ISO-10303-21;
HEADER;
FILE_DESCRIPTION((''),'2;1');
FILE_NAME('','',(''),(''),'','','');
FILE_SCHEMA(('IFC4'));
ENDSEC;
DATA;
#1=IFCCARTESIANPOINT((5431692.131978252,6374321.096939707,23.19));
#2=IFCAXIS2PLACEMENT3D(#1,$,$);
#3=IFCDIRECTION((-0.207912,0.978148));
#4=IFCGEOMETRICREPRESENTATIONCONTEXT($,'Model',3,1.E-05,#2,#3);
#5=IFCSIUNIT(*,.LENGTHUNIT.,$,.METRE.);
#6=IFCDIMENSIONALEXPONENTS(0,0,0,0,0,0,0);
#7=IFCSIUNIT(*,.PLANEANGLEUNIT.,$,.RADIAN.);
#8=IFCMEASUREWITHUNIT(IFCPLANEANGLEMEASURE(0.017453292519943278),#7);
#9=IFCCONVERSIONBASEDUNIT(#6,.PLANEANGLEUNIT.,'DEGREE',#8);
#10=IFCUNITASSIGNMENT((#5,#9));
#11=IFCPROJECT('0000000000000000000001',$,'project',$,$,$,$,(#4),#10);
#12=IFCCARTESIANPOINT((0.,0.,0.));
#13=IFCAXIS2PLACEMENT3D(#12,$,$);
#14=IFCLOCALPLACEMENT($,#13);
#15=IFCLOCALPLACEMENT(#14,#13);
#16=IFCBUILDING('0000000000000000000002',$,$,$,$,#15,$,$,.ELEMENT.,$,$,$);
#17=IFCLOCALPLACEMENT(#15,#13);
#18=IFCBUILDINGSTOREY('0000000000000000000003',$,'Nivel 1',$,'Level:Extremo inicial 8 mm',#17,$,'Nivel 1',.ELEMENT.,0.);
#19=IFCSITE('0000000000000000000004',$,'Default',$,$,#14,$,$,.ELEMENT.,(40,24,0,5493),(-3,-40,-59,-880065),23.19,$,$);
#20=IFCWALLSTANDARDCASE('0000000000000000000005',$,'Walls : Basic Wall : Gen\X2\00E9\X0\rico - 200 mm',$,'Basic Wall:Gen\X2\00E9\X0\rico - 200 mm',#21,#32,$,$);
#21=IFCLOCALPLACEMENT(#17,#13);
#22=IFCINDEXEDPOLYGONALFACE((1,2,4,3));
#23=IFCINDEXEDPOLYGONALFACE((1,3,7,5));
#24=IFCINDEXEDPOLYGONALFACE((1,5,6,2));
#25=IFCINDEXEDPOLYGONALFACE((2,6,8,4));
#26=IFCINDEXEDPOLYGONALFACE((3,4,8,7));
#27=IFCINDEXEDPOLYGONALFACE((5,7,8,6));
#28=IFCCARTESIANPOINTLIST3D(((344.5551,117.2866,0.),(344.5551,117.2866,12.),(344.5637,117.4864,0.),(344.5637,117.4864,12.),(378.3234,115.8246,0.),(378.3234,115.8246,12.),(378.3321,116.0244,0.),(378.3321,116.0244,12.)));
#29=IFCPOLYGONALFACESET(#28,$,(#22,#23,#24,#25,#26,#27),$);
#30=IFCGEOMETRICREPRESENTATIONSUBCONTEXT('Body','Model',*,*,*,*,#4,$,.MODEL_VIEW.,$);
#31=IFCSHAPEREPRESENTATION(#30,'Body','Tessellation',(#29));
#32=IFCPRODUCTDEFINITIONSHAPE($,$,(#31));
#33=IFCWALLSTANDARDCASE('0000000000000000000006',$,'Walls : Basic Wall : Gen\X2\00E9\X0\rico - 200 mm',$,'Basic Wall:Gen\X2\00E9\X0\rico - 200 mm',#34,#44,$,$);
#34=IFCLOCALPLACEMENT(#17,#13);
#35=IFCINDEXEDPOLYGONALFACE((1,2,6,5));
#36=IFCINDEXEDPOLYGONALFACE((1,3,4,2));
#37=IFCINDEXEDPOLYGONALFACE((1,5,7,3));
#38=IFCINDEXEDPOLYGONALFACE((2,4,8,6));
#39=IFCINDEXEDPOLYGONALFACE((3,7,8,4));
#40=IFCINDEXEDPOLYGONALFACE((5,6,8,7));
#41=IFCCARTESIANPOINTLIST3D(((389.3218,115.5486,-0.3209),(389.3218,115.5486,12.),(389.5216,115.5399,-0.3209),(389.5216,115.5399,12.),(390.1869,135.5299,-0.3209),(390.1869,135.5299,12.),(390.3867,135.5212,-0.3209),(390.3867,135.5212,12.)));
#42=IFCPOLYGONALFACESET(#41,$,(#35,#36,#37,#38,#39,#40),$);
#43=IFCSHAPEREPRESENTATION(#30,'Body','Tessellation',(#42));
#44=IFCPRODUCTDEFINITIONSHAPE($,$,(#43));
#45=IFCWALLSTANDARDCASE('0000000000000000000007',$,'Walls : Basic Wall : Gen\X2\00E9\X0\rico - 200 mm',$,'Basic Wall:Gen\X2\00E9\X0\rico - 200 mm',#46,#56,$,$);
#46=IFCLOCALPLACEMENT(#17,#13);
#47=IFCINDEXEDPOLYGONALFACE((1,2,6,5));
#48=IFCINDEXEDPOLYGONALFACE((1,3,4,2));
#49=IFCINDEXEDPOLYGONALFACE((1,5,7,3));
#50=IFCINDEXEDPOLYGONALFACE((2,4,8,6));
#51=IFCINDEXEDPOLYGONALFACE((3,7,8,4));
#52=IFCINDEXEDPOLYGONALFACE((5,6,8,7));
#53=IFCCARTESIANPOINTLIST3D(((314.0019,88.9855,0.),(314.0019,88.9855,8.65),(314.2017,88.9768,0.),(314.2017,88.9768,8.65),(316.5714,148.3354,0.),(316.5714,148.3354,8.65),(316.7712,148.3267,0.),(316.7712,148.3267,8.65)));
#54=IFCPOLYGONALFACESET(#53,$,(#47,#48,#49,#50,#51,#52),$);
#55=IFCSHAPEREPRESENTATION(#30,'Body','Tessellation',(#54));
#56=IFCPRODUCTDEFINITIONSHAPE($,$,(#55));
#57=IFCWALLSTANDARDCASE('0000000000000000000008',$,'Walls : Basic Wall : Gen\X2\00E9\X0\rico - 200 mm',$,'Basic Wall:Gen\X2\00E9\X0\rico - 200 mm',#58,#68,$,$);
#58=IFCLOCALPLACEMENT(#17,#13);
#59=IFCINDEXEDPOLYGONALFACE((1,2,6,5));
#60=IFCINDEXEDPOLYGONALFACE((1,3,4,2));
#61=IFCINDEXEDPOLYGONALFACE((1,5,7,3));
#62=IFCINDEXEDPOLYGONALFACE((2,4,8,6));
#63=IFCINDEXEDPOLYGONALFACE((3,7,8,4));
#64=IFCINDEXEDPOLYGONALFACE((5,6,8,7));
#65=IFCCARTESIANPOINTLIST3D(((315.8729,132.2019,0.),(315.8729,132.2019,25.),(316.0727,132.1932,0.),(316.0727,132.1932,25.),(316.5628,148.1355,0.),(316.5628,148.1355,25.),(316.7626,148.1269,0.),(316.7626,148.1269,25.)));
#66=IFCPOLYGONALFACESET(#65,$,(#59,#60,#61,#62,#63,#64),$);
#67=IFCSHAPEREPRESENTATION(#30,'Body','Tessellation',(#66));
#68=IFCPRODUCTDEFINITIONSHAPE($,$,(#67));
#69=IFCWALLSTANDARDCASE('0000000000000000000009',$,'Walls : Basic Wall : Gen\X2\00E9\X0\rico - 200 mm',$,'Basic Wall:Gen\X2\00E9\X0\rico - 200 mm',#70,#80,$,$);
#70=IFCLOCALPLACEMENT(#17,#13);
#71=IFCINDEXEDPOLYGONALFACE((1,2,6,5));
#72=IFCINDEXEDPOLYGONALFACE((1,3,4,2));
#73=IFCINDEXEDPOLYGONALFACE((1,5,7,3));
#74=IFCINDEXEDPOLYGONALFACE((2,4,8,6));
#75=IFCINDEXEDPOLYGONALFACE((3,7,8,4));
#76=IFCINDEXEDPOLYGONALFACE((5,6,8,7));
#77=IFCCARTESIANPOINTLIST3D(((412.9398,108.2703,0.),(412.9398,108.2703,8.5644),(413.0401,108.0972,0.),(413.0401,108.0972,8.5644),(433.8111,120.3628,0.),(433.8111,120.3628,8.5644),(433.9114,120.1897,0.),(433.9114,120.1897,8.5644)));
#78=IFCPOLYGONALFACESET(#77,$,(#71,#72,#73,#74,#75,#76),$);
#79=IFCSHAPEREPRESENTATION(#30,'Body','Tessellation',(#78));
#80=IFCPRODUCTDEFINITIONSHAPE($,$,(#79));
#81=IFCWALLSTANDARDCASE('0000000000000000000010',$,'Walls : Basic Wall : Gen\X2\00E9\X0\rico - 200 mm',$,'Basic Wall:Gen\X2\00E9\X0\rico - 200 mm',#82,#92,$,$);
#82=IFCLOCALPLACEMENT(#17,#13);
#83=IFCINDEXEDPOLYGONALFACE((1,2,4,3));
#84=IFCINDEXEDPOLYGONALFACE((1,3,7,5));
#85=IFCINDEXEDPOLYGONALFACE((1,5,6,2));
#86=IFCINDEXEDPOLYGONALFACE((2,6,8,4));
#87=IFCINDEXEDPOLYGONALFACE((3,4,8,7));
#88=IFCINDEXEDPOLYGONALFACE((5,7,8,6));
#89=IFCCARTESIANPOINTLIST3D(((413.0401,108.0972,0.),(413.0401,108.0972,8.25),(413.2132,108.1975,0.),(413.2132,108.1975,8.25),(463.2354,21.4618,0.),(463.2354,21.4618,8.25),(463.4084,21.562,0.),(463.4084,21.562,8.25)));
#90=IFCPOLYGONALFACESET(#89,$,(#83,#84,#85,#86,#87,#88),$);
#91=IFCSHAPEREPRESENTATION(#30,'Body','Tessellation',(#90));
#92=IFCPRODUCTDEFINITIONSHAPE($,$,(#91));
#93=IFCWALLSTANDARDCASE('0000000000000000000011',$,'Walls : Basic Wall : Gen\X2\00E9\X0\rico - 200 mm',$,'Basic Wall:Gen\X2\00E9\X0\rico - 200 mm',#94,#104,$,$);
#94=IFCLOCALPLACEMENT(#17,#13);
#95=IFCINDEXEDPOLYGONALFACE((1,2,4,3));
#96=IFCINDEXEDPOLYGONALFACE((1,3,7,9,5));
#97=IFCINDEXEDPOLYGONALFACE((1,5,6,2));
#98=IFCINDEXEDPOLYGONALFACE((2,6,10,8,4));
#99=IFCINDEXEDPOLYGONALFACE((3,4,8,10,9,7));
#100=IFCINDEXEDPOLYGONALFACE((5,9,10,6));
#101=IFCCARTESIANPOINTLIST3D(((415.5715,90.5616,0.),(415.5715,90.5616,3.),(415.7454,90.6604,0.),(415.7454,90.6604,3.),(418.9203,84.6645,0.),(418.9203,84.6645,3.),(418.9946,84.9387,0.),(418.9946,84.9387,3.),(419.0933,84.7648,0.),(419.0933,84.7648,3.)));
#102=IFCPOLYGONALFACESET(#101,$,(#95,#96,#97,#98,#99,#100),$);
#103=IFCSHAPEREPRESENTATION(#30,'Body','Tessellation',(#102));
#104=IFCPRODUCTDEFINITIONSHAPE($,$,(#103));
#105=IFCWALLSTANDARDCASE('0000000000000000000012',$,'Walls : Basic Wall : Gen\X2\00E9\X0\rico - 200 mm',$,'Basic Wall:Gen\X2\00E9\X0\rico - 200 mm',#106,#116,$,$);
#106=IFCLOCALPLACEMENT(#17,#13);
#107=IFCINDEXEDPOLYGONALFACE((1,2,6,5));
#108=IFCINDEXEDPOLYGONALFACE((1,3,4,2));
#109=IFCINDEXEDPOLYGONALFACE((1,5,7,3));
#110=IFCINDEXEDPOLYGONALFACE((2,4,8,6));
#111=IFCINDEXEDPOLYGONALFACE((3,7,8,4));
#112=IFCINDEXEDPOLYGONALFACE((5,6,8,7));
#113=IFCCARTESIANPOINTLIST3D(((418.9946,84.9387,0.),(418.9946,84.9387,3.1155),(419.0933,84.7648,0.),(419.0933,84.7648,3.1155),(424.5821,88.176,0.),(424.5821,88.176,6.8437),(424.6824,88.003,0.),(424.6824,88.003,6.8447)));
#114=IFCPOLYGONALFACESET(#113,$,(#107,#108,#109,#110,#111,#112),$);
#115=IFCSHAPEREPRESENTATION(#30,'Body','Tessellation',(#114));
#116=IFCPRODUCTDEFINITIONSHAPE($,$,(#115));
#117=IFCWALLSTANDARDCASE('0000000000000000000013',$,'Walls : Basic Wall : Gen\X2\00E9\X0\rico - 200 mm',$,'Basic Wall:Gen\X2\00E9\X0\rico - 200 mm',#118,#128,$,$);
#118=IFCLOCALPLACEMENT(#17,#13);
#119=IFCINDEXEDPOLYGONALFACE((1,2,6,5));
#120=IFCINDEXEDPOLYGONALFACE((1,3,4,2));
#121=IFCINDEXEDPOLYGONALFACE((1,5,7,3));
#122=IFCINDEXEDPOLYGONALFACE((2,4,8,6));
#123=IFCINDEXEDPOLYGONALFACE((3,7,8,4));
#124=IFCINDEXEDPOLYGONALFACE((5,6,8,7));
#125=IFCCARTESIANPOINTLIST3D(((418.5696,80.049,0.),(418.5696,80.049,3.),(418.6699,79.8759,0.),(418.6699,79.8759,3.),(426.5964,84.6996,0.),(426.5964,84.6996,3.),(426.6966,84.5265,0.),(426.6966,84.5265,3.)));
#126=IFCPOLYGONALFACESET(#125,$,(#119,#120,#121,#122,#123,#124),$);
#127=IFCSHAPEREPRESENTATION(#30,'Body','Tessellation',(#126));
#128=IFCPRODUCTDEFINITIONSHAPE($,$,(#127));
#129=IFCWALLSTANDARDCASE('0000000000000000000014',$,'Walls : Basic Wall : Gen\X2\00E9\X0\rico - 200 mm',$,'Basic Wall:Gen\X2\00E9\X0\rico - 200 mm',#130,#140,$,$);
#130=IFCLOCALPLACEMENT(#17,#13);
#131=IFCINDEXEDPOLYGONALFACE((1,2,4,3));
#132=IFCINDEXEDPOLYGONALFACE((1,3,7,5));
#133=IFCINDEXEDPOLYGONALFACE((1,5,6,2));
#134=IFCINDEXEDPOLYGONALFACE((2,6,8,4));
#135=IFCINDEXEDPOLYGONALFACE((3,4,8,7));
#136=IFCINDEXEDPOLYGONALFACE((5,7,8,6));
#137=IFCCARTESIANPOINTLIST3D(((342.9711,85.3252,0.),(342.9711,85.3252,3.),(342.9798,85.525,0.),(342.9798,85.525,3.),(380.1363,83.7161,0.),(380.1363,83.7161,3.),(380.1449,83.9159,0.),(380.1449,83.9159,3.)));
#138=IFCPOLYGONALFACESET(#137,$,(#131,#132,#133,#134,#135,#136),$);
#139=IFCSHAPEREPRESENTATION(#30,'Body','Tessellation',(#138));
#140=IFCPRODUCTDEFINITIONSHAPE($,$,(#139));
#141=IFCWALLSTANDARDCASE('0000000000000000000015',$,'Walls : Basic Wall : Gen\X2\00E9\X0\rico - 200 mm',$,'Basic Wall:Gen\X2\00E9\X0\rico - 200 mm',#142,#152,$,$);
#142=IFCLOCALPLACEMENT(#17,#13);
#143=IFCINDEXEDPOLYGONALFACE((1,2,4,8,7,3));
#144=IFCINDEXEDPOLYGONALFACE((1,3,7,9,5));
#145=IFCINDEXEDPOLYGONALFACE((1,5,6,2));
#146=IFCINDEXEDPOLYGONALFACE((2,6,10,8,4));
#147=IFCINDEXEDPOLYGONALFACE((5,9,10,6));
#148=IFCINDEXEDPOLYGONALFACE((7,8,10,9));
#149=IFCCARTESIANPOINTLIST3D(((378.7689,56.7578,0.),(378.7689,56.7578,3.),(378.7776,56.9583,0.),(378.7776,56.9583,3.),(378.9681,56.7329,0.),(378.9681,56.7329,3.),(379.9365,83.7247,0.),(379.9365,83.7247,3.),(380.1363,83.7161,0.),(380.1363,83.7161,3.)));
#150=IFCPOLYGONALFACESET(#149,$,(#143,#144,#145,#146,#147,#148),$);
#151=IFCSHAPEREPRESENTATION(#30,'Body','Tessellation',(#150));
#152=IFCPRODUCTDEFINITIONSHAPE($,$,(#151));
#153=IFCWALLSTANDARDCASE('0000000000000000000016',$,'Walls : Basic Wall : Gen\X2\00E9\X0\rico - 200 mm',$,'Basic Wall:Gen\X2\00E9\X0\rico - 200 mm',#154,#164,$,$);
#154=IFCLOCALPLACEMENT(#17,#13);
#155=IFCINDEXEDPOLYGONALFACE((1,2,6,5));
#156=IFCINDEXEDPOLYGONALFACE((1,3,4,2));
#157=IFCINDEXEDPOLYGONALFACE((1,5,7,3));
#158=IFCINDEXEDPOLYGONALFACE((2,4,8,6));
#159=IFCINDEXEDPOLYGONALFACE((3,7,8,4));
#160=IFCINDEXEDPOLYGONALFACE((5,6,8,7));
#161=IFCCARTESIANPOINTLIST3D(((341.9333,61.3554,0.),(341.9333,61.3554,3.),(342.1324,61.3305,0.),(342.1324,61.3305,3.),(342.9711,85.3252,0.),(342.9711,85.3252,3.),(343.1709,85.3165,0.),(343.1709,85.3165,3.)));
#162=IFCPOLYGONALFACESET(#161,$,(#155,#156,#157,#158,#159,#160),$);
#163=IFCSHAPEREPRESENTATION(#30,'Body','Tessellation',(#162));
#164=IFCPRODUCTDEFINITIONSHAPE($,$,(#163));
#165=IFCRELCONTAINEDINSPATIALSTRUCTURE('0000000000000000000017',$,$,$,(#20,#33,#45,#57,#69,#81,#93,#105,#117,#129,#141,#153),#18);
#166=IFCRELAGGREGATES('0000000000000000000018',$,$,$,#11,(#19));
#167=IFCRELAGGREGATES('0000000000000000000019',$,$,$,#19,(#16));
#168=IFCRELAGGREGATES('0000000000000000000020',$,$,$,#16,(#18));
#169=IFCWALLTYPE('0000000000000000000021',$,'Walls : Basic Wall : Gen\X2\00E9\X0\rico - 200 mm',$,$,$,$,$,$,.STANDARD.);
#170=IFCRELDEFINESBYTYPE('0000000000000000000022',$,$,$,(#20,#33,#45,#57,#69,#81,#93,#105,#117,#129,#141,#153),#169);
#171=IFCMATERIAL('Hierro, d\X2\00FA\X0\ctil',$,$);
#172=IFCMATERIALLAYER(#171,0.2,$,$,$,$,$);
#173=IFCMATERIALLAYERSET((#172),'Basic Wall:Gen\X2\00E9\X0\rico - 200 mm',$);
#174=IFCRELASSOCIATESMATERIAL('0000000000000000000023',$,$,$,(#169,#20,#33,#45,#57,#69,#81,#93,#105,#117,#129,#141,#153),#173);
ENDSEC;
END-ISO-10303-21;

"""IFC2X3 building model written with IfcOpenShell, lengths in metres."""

from ifc_helpers import new_model, entity, si_unit, converted_unit, direction, frame, frame_2d, origin, place, context, subcontext, project, spatial, polyline, rectangle, outline, extrude, clip, bounded_halfspace, material, layer, layer_set, layer_usage, type_object, element, save


model = new_model("IFC2X3")

# Units and contexts
model_context = context("Model", 3, precision=1e-05, world=frame((5431692.131978252, 6374321.096939707, 23.19)), true_north=direction((-0.207912, 0.978148)))
body_context = subcontext(model_context, "Body", "Model", "MODEL_VIEW")
ifc_project = project(units=[si_unit("LENGTHUNIT", "METRE"), converted_unit("PLANEANGLEUNIT", "DEGREE", entity("IfcPlaneAngleMeasure", 0.017453292519943278), si_unit("PLANEANGLEUNIT", "RADIAN"), dimensions=[0, 0, 0, 0, 0, 0, 0])], contexts=[model_context])

# Site, building, storey
site_placement = place(None, origin())
site = spatial("IfcSite", under=ifc_project, at=site_placement, Name="Default", CompositionType="ELEMENT", RefLatitude=(40, 24, 0, 5493), RefLongitude=(-3, -40, -59, -880065), RefElevation=23.19)
building_placement = place(site_placement, origin())
building = spatial("IfcBuilding", under=site, at=building_placement, CompositionType="ELEMENT")
storey_placement = place(building_placement, origin())
storey = spatial("IfcBuildingStorey", under=building, at=storey_placement, Name="Nivel 1", ObjectType="Level:Extremo inicial 8 mm", LongName="Nivel 1", CompositionType="ELEMENT", Elevation=0.0)

# Walls
ifc_material = material(Name="Hierro, dúctil")
ifc_layer = layer(ifc_material, 0.2)
ifc_layer_set = layer_set([ifc_layer], Name="Basic Wall:Genérico - 200 mm")
ifc_layer_usage_1 = layer_usage(ifc_layer_set, "AXIS2", "NEGATIVE", 0.1)
wall_type = type_object("IfcWallType", Name="Walls : Basic Wall : Genérico - 200 mm", PredefinedType="STANDARD", material=ifc_layer_set)
wall_1_placement = place(storey_placement, frame((344.5594, 117.3865, 0.0), z_axis=(0.0, 0.0, 1.0), x_axis=(0.999064, -0.043255, 0.0)))
element("IfcWallStandardCase", 1, at=wall_1_placement, inside=storey, type_object=wall_type, material=ifc_layer_usage_1, Name="Walls : Basic Wall : Genérico - 200 mm", ObjectType="Basic Wall:Genérico - 200 mm", context=body_context, shape_type="SweptSolid", body=[
    extrude(rectangle(XDim=33.8, YDim=0.2, at=frame_2d((16.9, 0.0), x_axis=(-1.0, 0.0))), origin(), (0.0, 0.0, 1.0), 12.0),
])
ifc_layer_usage_2 = layer_usage(ifc_layer_set, "AXIS2", "NEGATIVE", 0.1)
wall_2_placement = place(storey_placement, frame((389.4217, 115.5442, -0.3209), z_axis=(0.0, 0.0, 1.0), x_axis=(0.043255, 0.999064, 0.0)))
element("IfcWallStandardCase", 2, at=wall_2_placement, inside=storey, type_object=wall_type, material=ifc_layer_usage_2, Name="Walls : Basic Wall : Genérico - 200 mm", ObjectType="Basic Wall:Genérico - 200 mm", context=body_context, shape_type="Clipping", body=[
    clip(clip(extrude(rectangle(XDim=20.0, YDim=0.2, at=frame_2d((10.0, 0.0), x_axis=(-1.0, 0.0))), origin(), (0.0, 0.0, 1.0), 12.3209), bounded_halfspace(frame((9.8, -0.1, 12.3209), z_axis=(0.0, 0.0, 1.0), x_axis=(0.043255, -0.999064, 0.0)), False, frame((9.8, -0.1, 12.3209)), polyline([(0.0, 0.0), (10.2, 0.0), (10.2, 0.2), (10.0, 0.2), (0.0, 0.2), (0.0, 0.0)]))), bounded_halfspace(frame((0.0, -0.1, 12.3209), z_axis=(0.0, 0.0, 1.0), x_axis=(0.043255, -0.999064, 0.0)), False, frame((0.0, -0.1, 12.3209)), polyline([(0.0, 0.0), (9.8, 0.0), (9.8, 0.2), (0.0, 0.2), (0.0, 0.0)]))),
])
ifc_layer_usage_3 = layer_usage(ifc_layer_set, "AXIS2", "NEGATIVE", 0.1)
wall_3_placement = place(storey_placement, frame((314.1018, 88.9812, 0.0), z_axis=(0.0, 0.0, 1.0), x_axis=(0.043255, 0.999064, 0.0)))
element("IfcWallStandardCase", 3, at=wall_3_placement, inside=storey, type_object=wall_type, material=ifc_layer_usage_3, Name="Walls : Basic Wall : Genérico - 200 mm", ObjectType="Basic Wall:Genérico - 200 mm", context=body_context, shape_type="SweptSolid", body=[
    extrude(rectangle(XDim=59.4055, YDim=0.2, at=frame_2d((29.7027, 0.0), x_axis=(-1.0, 0.0))), origin(), (0.0, 0.0, 1.0), 8.65),
])
ifc_layer_usage_4 = layer_usage(ifc_layer_set, "AXIS2", "NEGATIVE", 0.1)
wall_4_placement = place(storey_placement, frame((315.9728, 132.1975, 0.0), z_axis=(0.0, 0.0, 1.0), x_axis=(0.043255, 0.999064, 0.0)))
element("IfcWallStandardCase", 4, at=wall_4_placement, inside=storey, type_object=wall_type, material=ifc_layer_usage_4, Name="Walls : Basic Wall : Genérico - 200 mm", ObjectType="Basic Wall:Genérico - 200 mm", context=body_context, shape_type="SweptSolid", body=[
    extrude(rectangle(XDim=15.9486, YDim=0.2, at=frame_2d((7.9743, 0.0), x_axis=(-1.0, 0.0))), origin(), (0.0, 0.0, 1.0), 25.0),
])
ifc_layer_usage_5 = layer_usage(ifc_layer_set, "AXIS2", "NEGATIVE", 0.1)
wall_5_placement = place(storey_placement, frame((433.8612, 120.2762, 0.0), z_axis=(0.0, 0.0, 1.0), x_axis=(-0.865262, -0.50132, 0.0)))
element("IfcWallStandardCase", 5, at=wall_5_placement, inside=storey, type_object=wall_type, material=ifc_layer_usage_5, Name="Walls : Basic Wall : Genérico - 200 mm", ObjectType="Basic Wall:Genérico - 200 mm", context=body_context, shape_type="SweptSolid", body=[
    extrude(rectangle(XDim=24.1213, YDim=0.2, at=frame_2d((12.0606, 0.0), x_axis=(-1.0, 0.0))), origin(), (0.0, 0.0, 1.0), 8.5644),
])
ifc_layer_usage_6 = layer_usage(ifc_layer_set, "AXIS2", "NEGATIVE", 0.1)
wall_6_placement = place(storey_placement, frame((413.1266, 108.1474, 0.0), z_axis=(0.0, 0.0, 1.0), x_axis=(0.50132, -0.865262, 0.0)))
element("IfcWallStandardCase", 6, at=wall_6_placement, inside=storey, type_object=wall_type, material=ifc_layer_usage_6, Name="Walls : Basic Wall : Genérico - 200 mm", ObjectType="Basic Wall:Genérico - 200 mm", context=body_context, shape_type="SweptSolid", body=[
    extrude(rectangle(XDim=100.1262, YDim=0.2, at=frame_2d((50.0631, 0.0), x_axis=(-1.0, 0.0))), origin(), (0.0, 0.0, 1.0), 8.25),
])
ifc_layer_usage_7 = layer_usage(ifc_layer_set, "AXIS2", "NEGATIVE", 0.1)
wall_7_placement = place(storey_placement, frame((415.6585, 90.611, 0.0), z_axis=(0.0, 0.0, 1.0), x_axis=(0.4938, -0.869576, 0.0)))
element("IfcWallStandardCase", 7, at=wall_7_placement, inside=storey, type_object=wall_type, material=ifc_layer_usage_7, Name="Walls : Basic Wall : Genérico - 200 mm", ObjectType="Basic Wall:Genérico - 200 mm", context=body_context, shape_type="SweptSolid", body=[
    extrude(outline(polyline([(6.7816, -0.1), (6.7799, 0.1), (6.5799, 0.1), (0.0, 0.1), (0.0, -0.1), (6.7816, -0.1)])), origin(), (0.0, 0.0, 1.0), 3.0),
])
ifc_layer_usage_8 = layer_usage(ifc_layer_set, "AXIS2", "NEGATIVE", 0.1)
wall_8_placement = place(storey_placement, frame((419.0432, 84.8513, 0.0), z_axis=(0.0, 0.0, 1.0), x_axis=(0.865262, 0.50132, 0.0)))
element("IfcWallStandardCase", 8, at=wall_8_placement, inside=storey, type_object=wall_type, material=ifc_layer_usage_8, Name="Walls : Basic Wall : Genérico - 200 mm", ObjectType="Basic Wall:Genérico - 200 mm", context=body_context, shape_type="Clipping", body=[
    clip(extrude(outline(polyline([(6.4594, -0.1), (6.4594, 0.1), (0.0017, 0.1), (0.0, -0.1), (6.4594, -0.1)])), origin(), (0.0, 0.0, 1.0), 6.8447), bounded_halfspace(frame((0.0, -0.1, 3.1155), z_axis=(-0.499981, 0.004335, 0.866025), x_axis=(-0.008669, -0.999962, 0.0)), False, frame((0.0, -0.1, 3.1155)), polyline([(0.0, 0.0), (6.4594, 0.0), (6.4594, 0.2), (0.0017, 0.2), (0.0, 0.0)]))),
])
ifc_layer_usage_9 = layer_usage(ifc_layer_set, "AXIS2", "NEGATIVE", 0.1)
wall_9_placement = place(storey_placement, frame((418.6197, 79.9624, 0.0), z_axis=(0.0, 0.0, 1.0), x_axis=(0.865262, 0.50132, 0.0)))
element("IfcWallStandardCase", 9, at=wall_9_placement, inside=storey, type_object=wall_type, material=ifc_layer_usage_9, Name="Walls : Basic Wall : Genérico - 200 mm", ObjectType="Basic Wall:Genérico - 200 mm", context=body_context, shape_type="SweptSolid", body=[
    extrude(rectangle(XDim=9.2767, YDim=0.2, at=frame_2d((4.6383, 0.0), x_axis=(-1.0, 0.0))), origin(), (0.0, 0.0, 1.0), 3.0),
])
ifc_layer_usage_10 = layer_usage(ifc_layer_set, "AXIS2", "NEGATIVE", 0.1)
wall_10_placement = place(storey_placement, frame((342.9754, 85.4251, 0.0), z_axis=(0.0, 0.0, 1.0), x_axis=(0.999064, -0.043255, 0.0)))
element("IfcWallStandardCase", 10, at=wall_10_placement, inside=storey, type_object=wall_type, material=ifc_layer_usage_10, Name="Walls : Basic Wall : Genérico - 200 mm", ObjectType="Basic Wall:Genérico - 200 mm", context=body_context, shape_type="SweptSolid", body=[
    extrude(rectangle(XDim=37.2, YDim=0.2, at=frame_2d((18.6, 0.0), x_axis=(-1.0, 0.0))), origin(), (0.0, 0.0, 1.0), 3.0),
])
ifc_layer_usage_11 = layer_usage(ifc_layer_set, "AXIS2", "NEGATIVE", 0.1)
wall_11_placement = place(storey_placement, frame((380.0364, 83.7204, 0.0), z_axis=(0.0, 0.0, 1.0), x_axis=(-0.043255, -0.999064, 0.0)))
element("IfcWallStandardCase", 11, at=wall_11_placement, inside=storey, type_object=wall_type, material=ifc_layer_usage_11, Name="Walls : Basic Wall : Genérico - 200 mm", ObjectType="Basic Wall:Genérico - 200 mm", context=body_context, shape_type="SweptSolid", body=[
    extrude(outline(polyline([(26.9922, -0.1), (27.0084, 0.1), (0.0, 0.1), (0.0, -0.1), (26.7916, -0.1), (26.9922, -0.1)])), origin(), (0.0, 0.0, 1.0), 3.0),
])
ifc_layer_usage_12 = layer_usage(ifc_layer_set, "AXIS2", "NEGATIVE", 0.1)
wall_12_placement = place(storey_placement, frame((343.071, 85.3208, 0.0), z_axis=(0.0, 0.0, 1.0), x_axis=(-0.043255, -0.999064, 0.0)))
element("IfcWallStandardCase", 12, at=wall_12_placement, inside=storey, type_object=wall_type, material=ifc_layer_usage_12, Name="Walls : Basic Wall : Genérico - 200 mm", ObjectType="Basic Wall:Genérico - 200 mm", context=body_context, shape_type="Clipping", body=[
    clip(extrude(outline(polyline([(23.9922, -0.1), (24.0084, 0.1), (23.8078, 0.1), (0.0, 0.1), (0.0, -0.1), (23.9922, -0.1)])), origin(), (0.0, 0.0, 1.0), 3.0), bounded_halfspace(frame((11.9, -0.1, 3.0), z_axis=(0.0, 0.0, 1.0), x_axis=(-0.043255, 0.999064, 0.0)), False, frame((11.9, -0.1, 3.0)), polyline([(0.0, 0.0), (12.0922, 0.0), (12.1084, 0.2), (11.9078, 0.2), (0.0, 0.2), (0.0, 0.0)]))),
])

save(model, "model.ifc")
